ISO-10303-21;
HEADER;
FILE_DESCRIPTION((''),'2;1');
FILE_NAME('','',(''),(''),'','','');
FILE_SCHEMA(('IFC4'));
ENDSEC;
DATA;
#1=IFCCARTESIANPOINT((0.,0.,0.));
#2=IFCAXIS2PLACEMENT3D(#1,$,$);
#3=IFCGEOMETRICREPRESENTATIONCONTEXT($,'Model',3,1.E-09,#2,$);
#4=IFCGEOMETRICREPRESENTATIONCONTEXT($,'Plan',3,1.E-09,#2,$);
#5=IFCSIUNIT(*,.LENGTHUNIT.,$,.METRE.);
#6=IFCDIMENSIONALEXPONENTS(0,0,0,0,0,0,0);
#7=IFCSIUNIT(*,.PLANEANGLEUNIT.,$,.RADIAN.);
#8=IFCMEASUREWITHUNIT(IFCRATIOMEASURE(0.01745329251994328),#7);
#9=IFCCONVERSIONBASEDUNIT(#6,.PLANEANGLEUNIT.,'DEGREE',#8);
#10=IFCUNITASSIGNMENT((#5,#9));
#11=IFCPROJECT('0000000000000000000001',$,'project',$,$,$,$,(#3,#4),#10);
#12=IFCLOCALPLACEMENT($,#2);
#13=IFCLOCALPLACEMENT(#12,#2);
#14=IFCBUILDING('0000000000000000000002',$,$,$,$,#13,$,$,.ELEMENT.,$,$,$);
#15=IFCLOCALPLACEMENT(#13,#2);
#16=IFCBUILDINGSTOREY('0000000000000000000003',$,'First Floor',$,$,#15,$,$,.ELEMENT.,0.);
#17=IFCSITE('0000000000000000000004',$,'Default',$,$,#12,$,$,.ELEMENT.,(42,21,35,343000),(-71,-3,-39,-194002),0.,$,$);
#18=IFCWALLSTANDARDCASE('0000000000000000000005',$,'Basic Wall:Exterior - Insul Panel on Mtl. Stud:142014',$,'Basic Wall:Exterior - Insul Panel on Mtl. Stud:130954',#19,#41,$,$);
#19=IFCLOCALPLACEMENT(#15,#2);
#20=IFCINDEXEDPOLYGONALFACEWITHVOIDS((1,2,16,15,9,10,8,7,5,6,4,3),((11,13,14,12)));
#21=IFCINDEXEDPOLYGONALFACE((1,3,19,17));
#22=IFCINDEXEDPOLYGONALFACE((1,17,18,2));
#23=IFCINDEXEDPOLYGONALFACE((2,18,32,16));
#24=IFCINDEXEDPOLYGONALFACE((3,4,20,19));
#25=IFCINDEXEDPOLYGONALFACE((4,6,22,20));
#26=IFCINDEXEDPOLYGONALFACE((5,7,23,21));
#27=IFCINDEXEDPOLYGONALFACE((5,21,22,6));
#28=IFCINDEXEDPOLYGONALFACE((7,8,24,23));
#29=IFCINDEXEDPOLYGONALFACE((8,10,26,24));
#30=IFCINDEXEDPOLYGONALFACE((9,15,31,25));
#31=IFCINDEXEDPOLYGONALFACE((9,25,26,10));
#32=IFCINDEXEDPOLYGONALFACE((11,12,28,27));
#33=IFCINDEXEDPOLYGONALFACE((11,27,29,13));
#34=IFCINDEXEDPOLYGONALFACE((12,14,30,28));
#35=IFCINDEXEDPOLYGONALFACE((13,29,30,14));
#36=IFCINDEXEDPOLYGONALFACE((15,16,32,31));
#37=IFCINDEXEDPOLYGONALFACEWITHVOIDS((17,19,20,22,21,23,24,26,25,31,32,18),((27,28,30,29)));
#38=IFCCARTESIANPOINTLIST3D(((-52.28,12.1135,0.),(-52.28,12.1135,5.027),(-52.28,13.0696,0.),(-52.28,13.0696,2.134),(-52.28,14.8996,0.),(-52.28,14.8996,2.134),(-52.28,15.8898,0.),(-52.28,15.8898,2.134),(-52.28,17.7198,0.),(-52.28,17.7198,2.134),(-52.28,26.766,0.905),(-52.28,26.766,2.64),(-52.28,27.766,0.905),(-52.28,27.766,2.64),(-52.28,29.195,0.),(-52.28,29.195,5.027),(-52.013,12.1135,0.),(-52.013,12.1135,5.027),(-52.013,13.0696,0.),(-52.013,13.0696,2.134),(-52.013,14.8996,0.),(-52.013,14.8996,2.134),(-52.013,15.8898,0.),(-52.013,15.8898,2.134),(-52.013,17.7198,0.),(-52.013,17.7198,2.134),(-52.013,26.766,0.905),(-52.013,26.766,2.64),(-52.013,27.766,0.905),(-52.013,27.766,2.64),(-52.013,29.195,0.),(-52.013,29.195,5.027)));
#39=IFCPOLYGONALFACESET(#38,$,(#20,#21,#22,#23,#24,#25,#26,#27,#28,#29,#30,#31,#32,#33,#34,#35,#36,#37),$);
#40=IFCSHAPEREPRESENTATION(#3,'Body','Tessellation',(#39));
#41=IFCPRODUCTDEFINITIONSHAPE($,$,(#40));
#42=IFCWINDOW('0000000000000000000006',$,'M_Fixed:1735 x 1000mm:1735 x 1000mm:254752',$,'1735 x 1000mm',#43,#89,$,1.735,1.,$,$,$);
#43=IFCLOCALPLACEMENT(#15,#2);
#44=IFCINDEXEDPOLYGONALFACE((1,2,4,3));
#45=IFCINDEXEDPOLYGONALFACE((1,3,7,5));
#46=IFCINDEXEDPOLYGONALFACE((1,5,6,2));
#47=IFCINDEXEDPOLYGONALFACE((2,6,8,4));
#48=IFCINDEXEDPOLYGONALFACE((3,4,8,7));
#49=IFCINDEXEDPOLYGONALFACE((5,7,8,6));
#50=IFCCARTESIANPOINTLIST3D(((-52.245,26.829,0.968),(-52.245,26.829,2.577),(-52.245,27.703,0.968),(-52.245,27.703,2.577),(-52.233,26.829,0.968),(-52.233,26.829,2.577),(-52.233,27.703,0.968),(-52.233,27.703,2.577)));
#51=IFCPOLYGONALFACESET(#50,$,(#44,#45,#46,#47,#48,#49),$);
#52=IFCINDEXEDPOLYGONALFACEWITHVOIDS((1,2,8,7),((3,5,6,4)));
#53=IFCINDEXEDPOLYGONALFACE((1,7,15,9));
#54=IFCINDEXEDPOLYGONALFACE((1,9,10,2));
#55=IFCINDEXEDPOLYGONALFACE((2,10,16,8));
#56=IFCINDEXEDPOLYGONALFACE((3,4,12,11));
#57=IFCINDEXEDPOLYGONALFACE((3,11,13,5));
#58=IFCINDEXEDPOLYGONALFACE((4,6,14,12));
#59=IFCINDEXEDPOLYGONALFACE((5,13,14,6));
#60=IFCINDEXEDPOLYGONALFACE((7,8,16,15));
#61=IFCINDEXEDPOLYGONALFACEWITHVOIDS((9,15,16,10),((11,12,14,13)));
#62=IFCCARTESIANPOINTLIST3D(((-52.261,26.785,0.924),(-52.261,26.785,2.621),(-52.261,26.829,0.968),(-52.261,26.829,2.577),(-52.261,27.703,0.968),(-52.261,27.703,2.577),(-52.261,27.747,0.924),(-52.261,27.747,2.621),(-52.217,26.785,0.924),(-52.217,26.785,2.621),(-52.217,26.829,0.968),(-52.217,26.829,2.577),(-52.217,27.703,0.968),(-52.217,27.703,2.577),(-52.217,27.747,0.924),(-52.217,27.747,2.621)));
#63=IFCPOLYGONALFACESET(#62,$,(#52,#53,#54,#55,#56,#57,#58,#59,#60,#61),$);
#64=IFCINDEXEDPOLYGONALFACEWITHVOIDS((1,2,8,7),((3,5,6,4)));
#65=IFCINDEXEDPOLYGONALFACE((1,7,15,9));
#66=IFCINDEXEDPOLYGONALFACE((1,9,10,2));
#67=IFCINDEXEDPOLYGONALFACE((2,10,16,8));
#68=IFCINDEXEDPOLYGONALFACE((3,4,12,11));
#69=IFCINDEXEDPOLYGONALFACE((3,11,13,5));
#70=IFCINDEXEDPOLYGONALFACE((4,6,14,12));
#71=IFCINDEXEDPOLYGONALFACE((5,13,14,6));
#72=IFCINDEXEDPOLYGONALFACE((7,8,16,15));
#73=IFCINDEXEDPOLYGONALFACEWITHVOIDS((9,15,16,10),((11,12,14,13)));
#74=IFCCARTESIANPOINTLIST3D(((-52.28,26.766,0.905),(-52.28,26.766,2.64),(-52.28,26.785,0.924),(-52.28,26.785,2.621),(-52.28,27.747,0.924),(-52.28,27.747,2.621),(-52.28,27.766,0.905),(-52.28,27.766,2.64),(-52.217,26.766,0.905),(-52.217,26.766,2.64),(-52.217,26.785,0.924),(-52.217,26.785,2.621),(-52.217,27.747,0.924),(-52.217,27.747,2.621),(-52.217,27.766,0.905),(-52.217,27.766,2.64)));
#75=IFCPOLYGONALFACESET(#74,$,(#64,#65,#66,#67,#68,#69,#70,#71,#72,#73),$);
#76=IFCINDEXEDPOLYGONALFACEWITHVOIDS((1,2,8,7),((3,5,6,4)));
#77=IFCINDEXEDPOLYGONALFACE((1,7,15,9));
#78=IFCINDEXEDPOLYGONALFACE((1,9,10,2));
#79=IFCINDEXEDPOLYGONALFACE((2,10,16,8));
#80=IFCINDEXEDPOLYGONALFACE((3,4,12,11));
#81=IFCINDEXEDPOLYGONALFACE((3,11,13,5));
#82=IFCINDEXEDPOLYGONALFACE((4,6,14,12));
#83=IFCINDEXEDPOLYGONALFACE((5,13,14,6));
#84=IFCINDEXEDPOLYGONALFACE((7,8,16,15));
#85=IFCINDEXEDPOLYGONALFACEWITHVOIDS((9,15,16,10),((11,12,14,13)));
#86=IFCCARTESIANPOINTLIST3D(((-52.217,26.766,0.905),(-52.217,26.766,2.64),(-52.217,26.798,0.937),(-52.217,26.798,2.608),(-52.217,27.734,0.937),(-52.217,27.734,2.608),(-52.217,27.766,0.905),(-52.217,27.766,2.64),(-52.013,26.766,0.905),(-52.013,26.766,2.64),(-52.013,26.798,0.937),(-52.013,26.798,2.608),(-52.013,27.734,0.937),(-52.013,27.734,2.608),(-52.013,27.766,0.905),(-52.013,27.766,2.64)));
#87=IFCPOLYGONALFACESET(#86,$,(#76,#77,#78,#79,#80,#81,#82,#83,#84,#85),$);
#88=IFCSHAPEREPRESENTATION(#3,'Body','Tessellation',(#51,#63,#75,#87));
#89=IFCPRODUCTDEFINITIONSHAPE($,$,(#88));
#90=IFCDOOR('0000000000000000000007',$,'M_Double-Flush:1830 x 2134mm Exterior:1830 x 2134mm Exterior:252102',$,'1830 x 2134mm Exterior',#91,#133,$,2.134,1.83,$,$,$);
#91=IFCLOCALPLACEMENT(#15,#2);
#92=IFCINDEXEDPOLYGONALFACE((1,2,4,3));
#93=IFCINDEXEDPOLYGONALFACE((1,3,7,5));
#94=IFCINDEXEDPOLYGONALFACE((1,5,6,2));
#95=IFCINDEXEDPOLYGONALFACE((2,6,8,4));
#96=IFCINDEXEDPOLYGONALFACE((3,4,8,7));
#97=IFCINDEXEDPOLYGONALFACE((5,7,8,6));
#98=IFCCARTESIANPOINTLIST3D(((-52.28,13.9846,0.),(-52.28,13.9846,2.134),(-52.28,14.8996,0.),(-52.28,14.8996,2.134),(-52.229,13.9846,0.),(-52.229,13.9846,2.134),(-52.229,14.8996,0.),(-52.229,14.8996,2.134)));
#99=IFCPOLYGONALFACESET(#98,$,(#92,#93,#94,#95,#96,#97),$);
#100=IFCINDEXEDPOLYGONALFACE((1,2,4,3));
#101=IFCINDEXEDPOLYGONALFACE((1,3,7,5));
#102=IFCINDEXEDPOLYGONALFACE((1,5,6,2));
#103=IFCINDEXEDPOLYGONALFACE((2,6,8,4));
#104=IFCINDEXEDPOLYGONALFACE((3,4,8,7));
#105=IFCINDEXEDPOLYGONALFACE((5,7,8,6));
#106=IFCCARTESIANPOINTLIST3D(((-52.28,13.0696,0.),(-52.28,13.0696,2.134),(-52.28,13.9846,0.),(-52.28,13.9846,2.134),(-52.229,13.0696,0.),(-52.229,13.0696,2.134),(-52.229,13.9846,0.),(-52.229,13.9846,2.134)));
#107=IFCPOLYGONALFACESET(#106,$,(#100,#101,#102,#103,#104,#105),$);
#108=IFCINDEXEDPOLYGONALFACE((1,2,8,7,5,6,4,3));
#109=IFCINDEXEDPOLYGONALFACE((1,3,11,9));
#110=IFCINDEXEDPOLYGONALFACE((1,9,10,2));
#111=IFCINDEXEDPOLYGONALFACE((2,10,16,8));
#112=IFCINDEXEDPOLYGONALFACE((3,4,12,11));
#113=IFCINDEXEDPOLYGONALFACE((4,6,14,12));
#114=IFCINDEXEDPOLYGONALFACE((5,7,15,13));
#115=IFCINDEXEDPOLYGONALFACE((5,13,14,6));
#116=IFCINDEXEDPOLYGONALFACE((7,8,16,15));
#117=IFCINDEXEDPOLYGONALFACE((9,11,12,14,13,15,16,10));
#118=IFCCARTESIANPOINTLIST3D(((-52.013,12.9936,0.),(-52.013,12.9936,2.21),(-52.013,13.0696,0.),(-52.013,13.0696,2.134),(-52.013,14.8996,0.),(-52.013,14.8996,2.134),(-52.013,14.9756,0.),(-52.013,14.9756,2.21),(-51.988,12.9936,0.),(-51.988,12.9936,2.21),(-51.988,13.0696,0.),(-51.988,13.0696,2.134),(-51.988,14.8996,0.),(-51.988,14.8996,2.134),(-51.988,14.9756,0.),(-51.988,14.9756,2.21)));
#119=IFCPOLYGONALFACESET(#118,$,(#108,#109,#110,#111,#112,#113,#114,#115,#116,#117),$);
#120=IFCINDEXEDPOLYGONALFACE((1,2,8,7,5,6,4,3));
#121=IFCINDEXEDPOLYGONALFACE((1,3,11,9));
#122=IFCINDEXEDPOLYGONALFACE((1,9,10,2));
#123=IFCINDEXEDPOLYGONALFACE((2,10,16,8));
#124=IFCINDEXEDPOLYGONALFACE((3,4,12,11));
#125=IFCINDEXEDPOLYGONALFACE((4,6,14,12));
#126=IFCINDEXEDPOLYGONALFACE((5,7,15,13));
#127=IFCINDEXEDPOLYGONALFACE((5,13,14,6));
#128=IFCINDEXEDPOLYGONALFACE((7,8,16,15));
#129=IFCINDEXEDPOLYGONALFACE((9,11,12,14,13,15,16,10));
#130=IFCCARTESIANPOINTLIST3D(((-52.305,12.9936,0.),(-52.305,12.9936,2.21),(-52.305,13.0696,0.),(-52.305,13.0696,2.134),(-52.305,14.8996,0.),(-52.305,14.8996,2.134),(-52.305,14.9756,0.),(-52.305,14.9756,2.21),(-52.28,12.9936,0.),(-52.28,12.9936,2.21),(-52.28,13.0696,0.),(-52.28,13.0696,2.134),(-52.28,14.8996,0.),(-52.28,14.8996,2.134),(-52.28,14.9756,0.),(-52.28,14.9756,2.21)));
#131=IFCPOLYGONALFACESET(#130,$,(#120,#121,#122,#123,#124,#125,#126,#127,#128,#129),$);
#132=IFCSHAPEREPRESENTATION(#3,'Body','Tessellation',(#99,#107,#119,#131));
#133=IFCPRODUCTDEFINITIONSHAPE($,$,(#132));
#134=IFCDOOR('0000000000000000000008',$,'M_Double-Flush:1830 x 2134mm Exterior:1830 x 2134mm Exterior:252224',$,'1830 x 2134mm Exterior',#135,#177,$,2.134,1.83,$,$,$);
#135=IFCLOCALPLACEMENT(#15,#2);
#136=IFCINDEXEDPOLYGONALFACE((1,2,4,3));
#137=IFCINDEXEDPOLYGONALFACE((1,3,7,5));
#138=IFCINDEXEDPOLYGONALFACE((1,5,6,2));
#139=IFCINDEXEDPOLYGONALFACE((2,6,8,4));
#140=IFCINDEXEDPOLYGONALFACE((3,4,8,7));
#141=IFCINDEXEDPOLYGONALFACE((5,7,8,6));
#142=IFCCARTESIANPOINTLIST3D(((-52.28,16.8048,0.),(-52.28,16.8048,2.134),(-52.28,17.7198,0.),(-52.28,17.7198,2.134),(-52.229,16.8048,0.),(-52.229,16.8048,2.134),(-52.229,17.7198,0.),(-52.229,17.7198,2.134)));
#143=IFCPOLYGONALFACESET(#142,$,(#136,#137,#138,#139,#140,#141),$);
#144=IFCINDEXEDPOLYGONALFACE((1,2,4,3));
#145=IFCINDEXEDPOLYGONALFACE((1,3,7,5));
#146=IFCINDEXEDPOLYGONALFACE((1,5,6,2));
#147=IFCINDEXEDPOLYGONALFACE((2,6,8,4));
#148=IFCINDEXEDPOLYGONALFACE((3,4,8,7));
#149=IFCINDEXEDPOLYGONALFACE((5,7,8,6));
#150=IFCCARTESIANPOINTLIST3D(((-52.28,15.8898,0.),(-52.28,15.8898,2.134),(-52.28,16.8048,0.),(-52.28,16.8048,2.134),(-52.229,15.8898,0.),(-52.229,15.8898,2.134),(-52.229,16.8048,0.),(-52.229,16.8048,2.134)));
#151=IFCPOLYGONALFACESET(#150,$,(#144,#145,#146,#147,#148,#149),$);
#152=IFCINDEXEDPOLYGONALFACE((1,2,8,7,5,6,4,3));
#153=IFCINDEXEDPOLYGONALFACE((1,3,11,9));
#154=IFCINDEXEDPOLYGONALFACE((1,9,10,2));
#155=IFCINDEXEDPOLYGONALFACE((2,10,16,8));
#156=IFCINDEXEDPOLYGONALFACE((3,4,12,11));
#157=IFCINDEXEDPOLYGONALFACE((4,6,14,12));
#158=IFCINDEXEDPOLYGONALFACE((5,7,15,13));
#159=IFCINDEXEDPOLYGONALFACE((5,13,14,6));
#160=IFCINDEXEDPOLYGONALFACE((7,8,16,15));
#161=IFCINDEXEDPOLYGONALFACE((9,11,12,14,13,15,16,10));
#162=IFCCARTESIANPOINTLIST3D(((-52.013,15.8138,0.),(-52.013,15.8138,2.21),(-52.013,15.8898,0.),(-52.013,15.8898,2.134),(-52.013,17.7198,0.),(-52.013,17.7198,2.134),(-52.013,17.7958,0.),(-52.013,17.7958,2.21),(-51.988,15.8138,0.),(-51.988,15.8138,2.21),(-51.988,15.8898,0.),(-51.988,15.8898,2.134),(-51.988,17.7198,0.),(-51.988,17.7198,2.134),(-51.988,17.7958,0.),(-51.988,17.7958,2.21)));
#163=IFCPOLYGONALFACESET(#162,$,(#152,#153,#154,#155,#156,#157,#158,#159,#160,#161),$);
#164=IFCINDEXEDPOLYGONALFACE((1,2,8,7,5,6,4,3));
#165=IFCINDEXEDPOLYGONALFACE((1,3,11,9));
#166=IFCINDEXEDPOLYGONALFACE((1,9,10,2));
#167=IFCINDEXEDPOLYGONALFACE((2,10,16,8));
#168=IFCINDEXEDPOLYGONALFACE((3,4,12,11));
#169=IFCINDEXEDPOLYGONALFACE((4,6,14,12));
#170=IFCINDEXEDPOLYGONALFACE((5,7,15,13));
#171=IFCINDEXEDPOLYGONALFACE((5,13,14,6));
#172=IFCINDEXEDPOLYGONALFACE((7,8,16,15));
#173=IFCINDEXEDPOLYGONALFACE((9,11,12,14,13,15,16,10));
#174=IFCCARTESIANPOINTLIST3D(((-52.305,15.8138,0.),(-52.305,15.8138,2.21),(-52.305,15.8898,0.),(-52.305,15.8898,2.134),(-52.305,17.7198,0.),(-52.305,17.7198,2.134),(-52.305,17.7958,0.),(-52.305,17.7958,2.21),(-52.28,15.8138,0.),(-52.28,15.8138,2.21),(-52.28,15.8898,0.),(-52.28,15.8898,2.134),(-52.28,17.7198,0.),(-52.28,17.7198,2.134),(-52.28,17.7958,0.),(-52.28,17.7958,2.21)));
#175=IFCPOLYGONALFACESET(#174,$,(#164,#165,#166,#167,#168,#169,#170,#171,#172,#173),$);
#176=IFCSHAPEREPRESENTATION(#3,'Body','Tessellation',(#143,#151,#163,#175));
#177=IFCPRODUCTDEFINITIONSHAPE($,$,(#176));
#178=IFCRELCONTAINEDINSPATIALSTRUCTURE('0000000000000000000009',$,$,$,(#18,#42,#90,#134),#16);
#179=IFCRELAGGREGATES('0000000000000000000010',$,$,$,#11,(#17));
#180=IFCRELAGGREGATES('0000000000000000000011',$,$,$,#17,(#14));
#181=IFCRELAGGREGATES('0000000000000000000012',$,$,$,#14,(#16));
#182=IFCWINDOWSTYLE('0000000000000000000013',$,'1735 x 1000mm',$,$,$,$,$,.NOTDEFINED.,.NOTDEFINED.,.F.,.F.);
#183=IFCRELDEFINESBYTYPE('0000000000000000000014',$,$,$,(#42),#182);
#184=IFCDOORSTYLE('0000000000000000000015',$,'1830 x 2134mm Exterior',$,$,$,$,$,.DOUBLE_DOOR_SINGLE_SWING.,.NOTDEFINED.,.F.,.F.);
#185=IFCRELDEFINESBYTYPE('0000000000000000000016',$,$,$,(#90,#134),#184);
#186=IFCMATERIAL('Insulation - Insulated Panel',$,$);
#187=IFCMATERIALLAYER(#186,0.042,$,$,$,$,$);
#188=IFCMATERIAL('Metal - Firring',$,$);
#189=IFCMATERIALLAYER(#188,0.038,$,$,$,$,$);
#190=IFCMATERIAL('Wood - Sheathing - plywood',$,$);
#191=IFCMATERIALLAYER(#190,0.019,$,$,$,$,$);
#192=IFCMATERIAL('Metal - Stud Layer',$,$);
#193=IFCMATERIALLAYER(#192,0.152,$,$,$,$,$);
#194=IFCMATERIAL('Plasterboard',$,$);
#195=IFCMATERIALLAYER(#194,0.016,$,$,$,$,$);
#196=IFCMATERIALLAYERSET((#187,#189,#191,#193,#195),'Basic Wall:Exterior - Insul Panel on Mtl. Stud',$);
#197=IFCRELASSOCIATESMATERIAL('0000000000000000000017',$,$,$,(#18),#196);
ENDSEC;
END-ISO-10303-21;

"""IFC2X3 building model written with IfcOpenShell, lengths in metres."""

from ifc_helpers import new_model, entity, si_unit, converted_unit, frame, frame_2d, origin, origin_2d_with_axis, place, context, project, spatial, polyline, rectangle, outline, extrude, source, transform, mapped, material, layer, layer_set, layer_usage, type_object, type_shapes, element, fill, save


model = new_model("IFC2X3")

# Units and contexts
model_context = context("Model", 3, precision=1e-09, world=origin())
plan_context = context("Plan", 3, precision=1e-09, world=origin())
ifc_project = project(units=[si_unit("LENGTHUNIT", "METRE"), converted_unit("PLANEANGLEUNIT", "DEGREE", entity("IfcRatioMeasure", 0.01745329251994328), si_unit("PLANEANGLEUNIT", "RADIAN"), dimensions=[0, 0, 0, 0, 0, 0, 0])], contexts=[model_context, plan_context])

# Site, building, storey
site_placement = place(None, origin())
site = spatial("IfcSite", under=ifc_project, at=site_placement, Name="Default", CompositionType="ELEMENT", RefLatitude=(42, 21, 35, 343000), RefLongitude=(-71, -3, -39, -194002), RefElevation=0.0)
building_placement = place(site_placement, origin())
building = spatial("IfcBuilding", under=site, at=building_placement, CompositionType="ELEMENT")
storey_placement = place(building_placement, origin())
storey = spatial("IfcBuildingStorey", under=building, at=storey_placement, Name="First Floor", CompositionType="ELEMENT", Elevation=0.0)

# Wall, openings, window, doors
ifc_material_1 = material(Name="Insulation - Insulated Panel")
ifc_layer_1 = layer(ifc_material_1, 0.042)
ifc_material_2 = material(Name="Metal - Firring")
ifc_layer_2 = layer(ifc_material_2, 0.038)
ifc_material_3 = material(Name="Wood - Sheathing - plywood")
ifc_layer_3 = layer(ifc_material_3, 0.019)
ifc_material_4 = material(Name="Metal - Stud Layer")
ifc_layer_4 = layer(ifc_material_4, 0.152)
ifc_material_5 = material(Name="Plasterboard")
ifc_layer_5 = layer(ifc_material_5, 0.016)
ifc_layer_set_1 = layer_set([ifc_layer_1, ifc_layer_2, ifc_layer_3, ifc_layer_4, ifc_layer_5], Name="Basic Wall:Exterior - Insul Panel on Mtl. Stud")
ifc_layer_usage_1 = layer_usage(ifc_layer_set_1, "AXIS2", "NEGATIVE", 0.1335)
wall_1_placement = place(storey_placement, frame((-52.1465, 12.1135, 0.0), z_axis=(0.0, 0.0, 1.0), x_axis=(0.0, 1.0, 0.0)))
wall_1 = element("IfcWallStandardCase", 1, at=wall_1_placement, inside=storey, material=ifc_layer_usage_1, Name="Basic Wall:Exterior - Insul Panel on Mtl. Stud:142014", ObjectType="Basic Wall:Exterior - Insul Panel on Mtl. Stud:130954", context=model_context, shape_type="SweptSolid", body=[
    extrude(rectangle(XDim=17.0815, YDim=0.267, at=frame_2d((8.5407, 0.0), x_axis=(1.0, 0.0))), origin(), (0.0, 0.0, 1.0), 5.027),
])
opening_1_placement = place(wall_1_placement, frame((0.9561, -0.1335, 0.0)))
opening_1 = element("IfcOpeningElement", 2, at=opening_1_placement, cuts=wall_1, ObjectType="Opening", context=model_context, shape_type="SweptSolid", body=[
    extrude(rectangle(XDim=2.134, YDim=1.83, at=frame_2d((1.067, 0.915), x_axis=(1.0, 0.0))), frame((0.0, 0.0, 0.0), z_axis=(0.0, 1.0, 0.0), x_axis=(0.0, 0.0, 1.0)), (0.0, 0.0, 1.0), 0.267),
])
opening_2_placement = place(wall_1_placement, frame((3.7763, -0.1335, 0.0)))
opening_2 = element("IfcOpeningElement", 3, at=opening_2_placement, cuts=wall_1, ObjectType="Opening", context=model_context, shape_type="SweptSolid", body=[
    extrude(rectangle(XDim=2.134, YDim=1.83, at=frame_2d((1.067, 0.915), x_axis=(1.0, 0.0))), frame((0.0, 0.0, 0.0), z_axis=(0.0, 1.0, 0.0), x_axis=(0.0, 0.0, 1.0)), (0.0, 0.0, 1.0), 0.267),
])
opening_3_placement = place(wall_1_placement, frame((14.6525, -0.1335, 0.905)))
opening_3 = element("IfcOpeningElement", 4, at=opening_3_placement, cuts=wall_1, ObjectType="Opening", context=model_context, shape_type="SweptSolid", body=[
    extrude(rectangle(XDim=1.735, YDim=1.0, at=frame_2d((0.8675, 0.5), x_axis=(1.0, 0.0))), frame((0.0, 0.0, 0.0), z_axis=(0.0, 1.0, 0.0), x_axis=(0.0, 0.0, 1.0)), (0.0, 0.0, 1.0), 0.267),
])
window_style = type_object("IfcWindowStyle", Name="1735 x 1000mm", ConstructionType="NOTDEFINED", OperationType="NOTDEFINED", ParameterTakesPrecedence=False, Sizeable=False)
shared_shape_1 = source(origin(), model_context, "Body", "SweptSolid", [
    extrude(rectangle(XDim=0.012, YDim=0.874, at=origin_2d_with_axis()), frame((0.5, 0.226, 0.063), z_axis=(0.0, 0.0, 1.0), x_axis=(0.0, -1.0, 0.0)), (0.0, 0.0, 1.0), 1.609),
    extrude(outline(polyline([(-0.481, -0.8485), (0.481, -0.8485), (0.481, 0.8485), (-0.481, 0.8485), (-0.481, -0.8485)]), holes=[polyline([(-0.437, -0.8045), (-0.437, 0.8045), (0.437, 0.8045), (0.437, -0.8045), (-0.437, -0.8045)])]), frame((0.5, 0.204, 0.8675), z_axis=(0.0, 1.0, 0.0), x_axis=(1.0, 0.0, 0.0)), (0.0, 0.0, 1.0), 0.044),
    extrude(outline(polyline([(-0.5, -0.8675), (0.5, -0.8675), (0.5, 0.8675), (-0.5, 0.8675), (-0.5, -0.8675)]), holes=[polyline([(-0.481, -0.8485), (-0.481, 0.8485), (0.481, 0.8485), (0.481, -0.8485), (-0.481, -0.8485)])]), frame((0.5, 0.204, 0.8675), z_axis=(0.0, 1.0, 0.0), x_axis=(1.0, 0.0, 0.0)), (0.0, 0.0, 1.0), 0.063),
    extrude(outline(polyline([(-0.5, -0.8675), (0.5, -0.8675), (0.5, 0.8675), (-0.5, 0.8675), (-0.5, -0.8675)]), holes=[polyline([(-0.468, -0.8355), (-0.468, 0.8355), (0.468, 0.8355), (0.468, -0.8355), (-0.468, -0.8355)])]), frame((0.5, 0.0, 0.8675), z_axis=(0.0, 1.0, 0.0), x_axis=(1.0, 0.0, 0.0)), (0.0, 0.0, 1.0), 0.204),
])
type_shapes(window_style, [shared_shape_1])
window_placement = place(opening_3_placement, origin())
window = element("IfcWindow", 5, at=window_placement, inside=storey, type_object=window_style, Name="M_Fixed:1735 x 1000mm:1735 x 1000mm:254752", ObjectType="1735 x 1000mm", OverallHeight=1.735, OverallWidth=1.0, context=model_context, shape_type="MappedRepresentation", body=[
    mapped(shared_shape_1, transform((0.0, 0.0, 0.0), scale=1.0)),
])
fill(opening_3, window)
door_style_1 = type_object("IfcDoorStyle", Name="1830 x 2134mm Exterior", ConstructionType="NOTDEFINED", OperationType="DOUBLE_DOOR_SINGLE_SWING", ParameterTakesPrecedence=False, Sizeable=False)
shared_shape_2 = source(origin(), model_context, "Body", "SweptSolid", [
    extrude(rectangle(XDim=0.051, YDim=0.915, at=origin_2d_with_axis()), frame((1.3725, 0.2415, 0.0), z_axis=(0.0, 0.0, 1.0), x_axis=(0.0, -1.0, 0.0)), (0.0, 0.0, 1.0), 2.134),
    extrude(rectangle(XDim=0.051, YDim=0.915, at=origin_2d_with_axis()), frame((0.4575, 0.2415, 0.0), z_axis=(0.0, 0.0, 1.0), x_axis=(0.0, -1.0, 0.0)), (0.0, 0.0, 1.0), 2.134),
    extrude(outline(polyline([(-1.048, 0.915), (1.086, 0.915), (1.086, 0.991), (-1.124, 0.991), (-1.124, -0.991), (1.086, -0.991), (1.086, -0.915), (-1.048, -0.915), (-1.048, 0.915)])), frame((0.915, -0.025, 1.086), z_axis=(0.0, 1.0, 0.0), x_axis=(0.0, 0.0, -1.0)), (0.0, 0.0, 1.0), 0.025),
    extrude(outline(polyline([(-1.048, 0.915), (1.086, 0.915), (1.086, 0.991), (-1.124, 0.991), (-1.124, -0.991), (1.086, -0.991), (1.086, -0.915), (-1.048, -0.915), (-1.048, 0.915)])), frame((0.915, 0.267, 1.086), z_axis=(0.0, 1.0, 0.0), x_axis=(0.0, 0.0, -1.0)), (0.0, 0.0, 1.0), 0.025),
])
type_shapes(door_style_1, [shared_shape_2])
door_1_placement = place(opening_1_placement, origin())
door_1 = element("IfcDoor", 6, at=door_1_placement, inside=storey, type_object=door_style_1, Name="M_Double-Flush:1830 x 2134mm Exterior:1830 x 2134mm Exterior:252102", ObjectType="1830 x 2134mm Exterior", OverallHeight=2.134, OverallWidth=1.83, context=model_context, shape_type="MappedRepresentation", body=[
    mapped(shared_shape_2, transform((0.0, 0.0, 0.0), scale=1.0)),
])
fill(opening_1, door_1)
door_2_placement = place(opening_2_placement, origin())
door_2 = element("IfcDoor", 7, at=door_2_placement, inside=storey, type_object=door_style_1, Name="M_Double-Flush:1830 x 2134mm Exterior:1830 x 2134mm Exterior:252224", ObjectType="1830 x 2134mm Exterior", OverallHeight=2.134, OverallWidth=1.83, context=model_context, shape_type="MappedRepresentation", body=[
    mapped(shared_shape_2, transform((0.0, 0.0, 0.0), scale=1.0)),
])
fill(opening_2, door_2)

save(model, "model.ifc")
